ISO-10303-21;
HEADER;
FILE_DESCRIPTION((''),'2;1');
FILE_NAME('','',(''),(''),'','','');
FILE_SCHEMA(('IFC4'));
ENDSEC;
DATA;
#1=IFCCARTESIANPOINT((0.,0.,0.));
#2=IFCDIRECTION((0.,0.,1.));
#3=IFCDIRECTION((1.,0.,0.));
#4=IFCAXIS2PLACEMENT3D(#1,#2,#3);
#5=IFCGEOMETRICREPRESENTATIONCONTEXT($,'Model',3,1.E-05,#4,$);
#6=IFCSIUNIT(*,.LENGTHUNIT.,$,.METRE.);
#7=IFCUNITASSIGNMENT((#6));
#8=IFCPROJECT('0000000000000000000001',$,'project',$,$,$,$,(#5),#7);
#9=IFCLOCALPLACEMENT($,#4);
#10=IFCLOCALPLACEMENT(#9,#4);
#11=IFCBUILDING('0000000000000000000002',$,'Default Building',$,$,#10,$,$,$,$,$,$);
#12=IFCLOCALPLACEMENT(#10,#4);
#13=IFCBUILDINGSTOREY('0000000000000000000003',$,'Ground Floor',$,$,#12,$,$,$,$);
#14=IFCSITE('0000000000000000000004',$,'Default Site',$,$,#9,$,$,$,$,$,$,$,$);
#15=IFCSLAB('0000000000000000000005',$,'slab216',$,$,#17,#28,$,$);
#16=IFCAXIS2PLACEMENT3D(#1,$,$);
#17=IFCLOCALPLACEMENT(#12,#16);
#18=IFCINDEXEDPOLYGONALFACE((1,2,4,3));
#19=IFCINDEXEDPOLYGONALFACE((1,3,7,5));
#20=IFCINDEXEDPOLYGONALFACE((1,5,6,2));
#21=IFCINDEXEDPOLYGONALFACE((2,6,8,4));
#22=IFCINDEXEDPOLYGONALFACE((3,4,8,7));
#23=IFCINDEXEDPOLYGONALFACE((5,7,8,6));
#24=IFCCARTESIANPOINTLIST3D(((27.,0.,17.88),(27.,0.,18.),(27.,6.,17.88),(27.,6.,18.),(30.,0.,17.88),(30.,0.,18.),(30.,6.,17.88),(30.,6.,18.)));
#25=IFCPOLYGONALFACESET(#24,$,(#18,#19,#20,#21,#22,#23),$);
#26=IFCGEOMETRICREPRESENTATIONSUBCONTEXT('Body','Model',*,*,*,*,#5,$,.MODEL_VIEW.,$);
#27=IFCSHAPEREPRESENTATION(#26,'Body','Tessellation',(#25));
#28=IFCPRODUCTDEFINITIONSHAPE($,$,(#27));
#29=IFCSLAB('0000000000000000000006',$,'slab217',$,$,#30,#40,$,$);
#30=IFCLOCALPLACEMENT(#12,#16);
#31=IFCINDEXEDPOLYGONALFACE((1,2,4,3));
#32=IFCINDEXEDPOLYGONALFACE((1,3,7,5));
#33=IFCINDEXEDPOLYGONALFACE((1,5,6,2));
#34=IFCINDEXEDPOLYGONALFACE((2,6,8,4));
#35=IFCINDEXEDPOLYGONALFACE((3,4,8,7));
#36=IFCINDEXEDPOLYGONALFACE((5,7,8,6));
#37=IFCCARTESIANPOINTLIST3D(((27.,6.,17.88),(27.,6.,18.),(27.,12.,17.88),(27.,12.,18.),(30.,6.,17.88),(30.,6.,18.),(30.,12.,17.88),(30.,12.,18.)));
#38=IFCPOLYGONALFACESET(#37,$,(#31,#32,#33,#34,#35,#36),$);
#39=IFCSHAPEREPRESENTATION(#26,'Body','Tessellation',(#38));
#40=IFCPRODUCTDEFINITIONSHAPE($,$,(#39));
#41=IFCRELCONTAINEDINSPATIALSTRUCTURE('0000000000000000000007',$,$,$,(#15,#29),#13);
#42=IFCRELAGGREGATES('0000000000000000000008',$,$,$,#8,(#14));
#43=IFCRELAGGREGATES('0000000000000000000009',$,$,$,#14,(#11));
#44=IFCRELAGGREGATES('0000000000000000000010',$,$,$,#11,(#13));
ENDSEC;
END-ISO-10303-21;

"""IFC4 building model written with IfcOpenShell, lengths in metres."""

from ifc_helpers import new_model, si_unit, frame, origin_with_axes, place, context, subcontext, project, spatial, indexed_curve, outline, extrude, element, save


model = new_model("IFC4")

# Units and contexts
model_context = context("Model", 3, precision=1e-05, world=origin_with_axes())
body_context = subcontext(model_context, "Body", "Model", "MODEL_VIEW")
ifc_project = project(units=[si_unit("LENGTHUNIT", "METRE")], contexts=[model_context])

# Site, building, storey
site_placement = place(None, origin_with_axes())
site = spatial("IfcSite", under=ifc_project, at=site_placement, Name="Default Site")
building_placement = place(site_placement, origin_with_axes())
building = spatial("IfcBuilding", under=site, at=building_placement, Name="Default Building")
storey_placement = place(building_placement, origin_with_axes())
storey = spatial("IfcBuildingStorey", under=building, at=storey_placement, Name="Ground Floor")

# Slabs
for number, where, z_axis, x_axis, name in (
    (1, (27.0, 0.0, 17.88), (0.0, 0.0, 1.0), (1.0, 0.0, 0.0), "slab216"),
    (2, (27.0, 6.0, 17.88), (0.0, 0.0, 1.0), (1.0, 0.0, 0.0), "slab217"),
):
    element("IfcSlab", number, at=place(storey_placement, frame(where, z_axis=z_axis, x_axis=x_axis)), inside=storey, Name=name, context=body_context, shape_type="SweptSolid", body=[
        extrude(outline(indexed_curve([(0.0, 0.0), (0.0, 6.0), (3.0, 6.0), (3.0, 0.0), (0.0, 0.0)], self_intersect=False)), origin_with_axes(), (0.0, 0.0, 1.0), 0.12),
    ])

save(model, "model.ifc")
